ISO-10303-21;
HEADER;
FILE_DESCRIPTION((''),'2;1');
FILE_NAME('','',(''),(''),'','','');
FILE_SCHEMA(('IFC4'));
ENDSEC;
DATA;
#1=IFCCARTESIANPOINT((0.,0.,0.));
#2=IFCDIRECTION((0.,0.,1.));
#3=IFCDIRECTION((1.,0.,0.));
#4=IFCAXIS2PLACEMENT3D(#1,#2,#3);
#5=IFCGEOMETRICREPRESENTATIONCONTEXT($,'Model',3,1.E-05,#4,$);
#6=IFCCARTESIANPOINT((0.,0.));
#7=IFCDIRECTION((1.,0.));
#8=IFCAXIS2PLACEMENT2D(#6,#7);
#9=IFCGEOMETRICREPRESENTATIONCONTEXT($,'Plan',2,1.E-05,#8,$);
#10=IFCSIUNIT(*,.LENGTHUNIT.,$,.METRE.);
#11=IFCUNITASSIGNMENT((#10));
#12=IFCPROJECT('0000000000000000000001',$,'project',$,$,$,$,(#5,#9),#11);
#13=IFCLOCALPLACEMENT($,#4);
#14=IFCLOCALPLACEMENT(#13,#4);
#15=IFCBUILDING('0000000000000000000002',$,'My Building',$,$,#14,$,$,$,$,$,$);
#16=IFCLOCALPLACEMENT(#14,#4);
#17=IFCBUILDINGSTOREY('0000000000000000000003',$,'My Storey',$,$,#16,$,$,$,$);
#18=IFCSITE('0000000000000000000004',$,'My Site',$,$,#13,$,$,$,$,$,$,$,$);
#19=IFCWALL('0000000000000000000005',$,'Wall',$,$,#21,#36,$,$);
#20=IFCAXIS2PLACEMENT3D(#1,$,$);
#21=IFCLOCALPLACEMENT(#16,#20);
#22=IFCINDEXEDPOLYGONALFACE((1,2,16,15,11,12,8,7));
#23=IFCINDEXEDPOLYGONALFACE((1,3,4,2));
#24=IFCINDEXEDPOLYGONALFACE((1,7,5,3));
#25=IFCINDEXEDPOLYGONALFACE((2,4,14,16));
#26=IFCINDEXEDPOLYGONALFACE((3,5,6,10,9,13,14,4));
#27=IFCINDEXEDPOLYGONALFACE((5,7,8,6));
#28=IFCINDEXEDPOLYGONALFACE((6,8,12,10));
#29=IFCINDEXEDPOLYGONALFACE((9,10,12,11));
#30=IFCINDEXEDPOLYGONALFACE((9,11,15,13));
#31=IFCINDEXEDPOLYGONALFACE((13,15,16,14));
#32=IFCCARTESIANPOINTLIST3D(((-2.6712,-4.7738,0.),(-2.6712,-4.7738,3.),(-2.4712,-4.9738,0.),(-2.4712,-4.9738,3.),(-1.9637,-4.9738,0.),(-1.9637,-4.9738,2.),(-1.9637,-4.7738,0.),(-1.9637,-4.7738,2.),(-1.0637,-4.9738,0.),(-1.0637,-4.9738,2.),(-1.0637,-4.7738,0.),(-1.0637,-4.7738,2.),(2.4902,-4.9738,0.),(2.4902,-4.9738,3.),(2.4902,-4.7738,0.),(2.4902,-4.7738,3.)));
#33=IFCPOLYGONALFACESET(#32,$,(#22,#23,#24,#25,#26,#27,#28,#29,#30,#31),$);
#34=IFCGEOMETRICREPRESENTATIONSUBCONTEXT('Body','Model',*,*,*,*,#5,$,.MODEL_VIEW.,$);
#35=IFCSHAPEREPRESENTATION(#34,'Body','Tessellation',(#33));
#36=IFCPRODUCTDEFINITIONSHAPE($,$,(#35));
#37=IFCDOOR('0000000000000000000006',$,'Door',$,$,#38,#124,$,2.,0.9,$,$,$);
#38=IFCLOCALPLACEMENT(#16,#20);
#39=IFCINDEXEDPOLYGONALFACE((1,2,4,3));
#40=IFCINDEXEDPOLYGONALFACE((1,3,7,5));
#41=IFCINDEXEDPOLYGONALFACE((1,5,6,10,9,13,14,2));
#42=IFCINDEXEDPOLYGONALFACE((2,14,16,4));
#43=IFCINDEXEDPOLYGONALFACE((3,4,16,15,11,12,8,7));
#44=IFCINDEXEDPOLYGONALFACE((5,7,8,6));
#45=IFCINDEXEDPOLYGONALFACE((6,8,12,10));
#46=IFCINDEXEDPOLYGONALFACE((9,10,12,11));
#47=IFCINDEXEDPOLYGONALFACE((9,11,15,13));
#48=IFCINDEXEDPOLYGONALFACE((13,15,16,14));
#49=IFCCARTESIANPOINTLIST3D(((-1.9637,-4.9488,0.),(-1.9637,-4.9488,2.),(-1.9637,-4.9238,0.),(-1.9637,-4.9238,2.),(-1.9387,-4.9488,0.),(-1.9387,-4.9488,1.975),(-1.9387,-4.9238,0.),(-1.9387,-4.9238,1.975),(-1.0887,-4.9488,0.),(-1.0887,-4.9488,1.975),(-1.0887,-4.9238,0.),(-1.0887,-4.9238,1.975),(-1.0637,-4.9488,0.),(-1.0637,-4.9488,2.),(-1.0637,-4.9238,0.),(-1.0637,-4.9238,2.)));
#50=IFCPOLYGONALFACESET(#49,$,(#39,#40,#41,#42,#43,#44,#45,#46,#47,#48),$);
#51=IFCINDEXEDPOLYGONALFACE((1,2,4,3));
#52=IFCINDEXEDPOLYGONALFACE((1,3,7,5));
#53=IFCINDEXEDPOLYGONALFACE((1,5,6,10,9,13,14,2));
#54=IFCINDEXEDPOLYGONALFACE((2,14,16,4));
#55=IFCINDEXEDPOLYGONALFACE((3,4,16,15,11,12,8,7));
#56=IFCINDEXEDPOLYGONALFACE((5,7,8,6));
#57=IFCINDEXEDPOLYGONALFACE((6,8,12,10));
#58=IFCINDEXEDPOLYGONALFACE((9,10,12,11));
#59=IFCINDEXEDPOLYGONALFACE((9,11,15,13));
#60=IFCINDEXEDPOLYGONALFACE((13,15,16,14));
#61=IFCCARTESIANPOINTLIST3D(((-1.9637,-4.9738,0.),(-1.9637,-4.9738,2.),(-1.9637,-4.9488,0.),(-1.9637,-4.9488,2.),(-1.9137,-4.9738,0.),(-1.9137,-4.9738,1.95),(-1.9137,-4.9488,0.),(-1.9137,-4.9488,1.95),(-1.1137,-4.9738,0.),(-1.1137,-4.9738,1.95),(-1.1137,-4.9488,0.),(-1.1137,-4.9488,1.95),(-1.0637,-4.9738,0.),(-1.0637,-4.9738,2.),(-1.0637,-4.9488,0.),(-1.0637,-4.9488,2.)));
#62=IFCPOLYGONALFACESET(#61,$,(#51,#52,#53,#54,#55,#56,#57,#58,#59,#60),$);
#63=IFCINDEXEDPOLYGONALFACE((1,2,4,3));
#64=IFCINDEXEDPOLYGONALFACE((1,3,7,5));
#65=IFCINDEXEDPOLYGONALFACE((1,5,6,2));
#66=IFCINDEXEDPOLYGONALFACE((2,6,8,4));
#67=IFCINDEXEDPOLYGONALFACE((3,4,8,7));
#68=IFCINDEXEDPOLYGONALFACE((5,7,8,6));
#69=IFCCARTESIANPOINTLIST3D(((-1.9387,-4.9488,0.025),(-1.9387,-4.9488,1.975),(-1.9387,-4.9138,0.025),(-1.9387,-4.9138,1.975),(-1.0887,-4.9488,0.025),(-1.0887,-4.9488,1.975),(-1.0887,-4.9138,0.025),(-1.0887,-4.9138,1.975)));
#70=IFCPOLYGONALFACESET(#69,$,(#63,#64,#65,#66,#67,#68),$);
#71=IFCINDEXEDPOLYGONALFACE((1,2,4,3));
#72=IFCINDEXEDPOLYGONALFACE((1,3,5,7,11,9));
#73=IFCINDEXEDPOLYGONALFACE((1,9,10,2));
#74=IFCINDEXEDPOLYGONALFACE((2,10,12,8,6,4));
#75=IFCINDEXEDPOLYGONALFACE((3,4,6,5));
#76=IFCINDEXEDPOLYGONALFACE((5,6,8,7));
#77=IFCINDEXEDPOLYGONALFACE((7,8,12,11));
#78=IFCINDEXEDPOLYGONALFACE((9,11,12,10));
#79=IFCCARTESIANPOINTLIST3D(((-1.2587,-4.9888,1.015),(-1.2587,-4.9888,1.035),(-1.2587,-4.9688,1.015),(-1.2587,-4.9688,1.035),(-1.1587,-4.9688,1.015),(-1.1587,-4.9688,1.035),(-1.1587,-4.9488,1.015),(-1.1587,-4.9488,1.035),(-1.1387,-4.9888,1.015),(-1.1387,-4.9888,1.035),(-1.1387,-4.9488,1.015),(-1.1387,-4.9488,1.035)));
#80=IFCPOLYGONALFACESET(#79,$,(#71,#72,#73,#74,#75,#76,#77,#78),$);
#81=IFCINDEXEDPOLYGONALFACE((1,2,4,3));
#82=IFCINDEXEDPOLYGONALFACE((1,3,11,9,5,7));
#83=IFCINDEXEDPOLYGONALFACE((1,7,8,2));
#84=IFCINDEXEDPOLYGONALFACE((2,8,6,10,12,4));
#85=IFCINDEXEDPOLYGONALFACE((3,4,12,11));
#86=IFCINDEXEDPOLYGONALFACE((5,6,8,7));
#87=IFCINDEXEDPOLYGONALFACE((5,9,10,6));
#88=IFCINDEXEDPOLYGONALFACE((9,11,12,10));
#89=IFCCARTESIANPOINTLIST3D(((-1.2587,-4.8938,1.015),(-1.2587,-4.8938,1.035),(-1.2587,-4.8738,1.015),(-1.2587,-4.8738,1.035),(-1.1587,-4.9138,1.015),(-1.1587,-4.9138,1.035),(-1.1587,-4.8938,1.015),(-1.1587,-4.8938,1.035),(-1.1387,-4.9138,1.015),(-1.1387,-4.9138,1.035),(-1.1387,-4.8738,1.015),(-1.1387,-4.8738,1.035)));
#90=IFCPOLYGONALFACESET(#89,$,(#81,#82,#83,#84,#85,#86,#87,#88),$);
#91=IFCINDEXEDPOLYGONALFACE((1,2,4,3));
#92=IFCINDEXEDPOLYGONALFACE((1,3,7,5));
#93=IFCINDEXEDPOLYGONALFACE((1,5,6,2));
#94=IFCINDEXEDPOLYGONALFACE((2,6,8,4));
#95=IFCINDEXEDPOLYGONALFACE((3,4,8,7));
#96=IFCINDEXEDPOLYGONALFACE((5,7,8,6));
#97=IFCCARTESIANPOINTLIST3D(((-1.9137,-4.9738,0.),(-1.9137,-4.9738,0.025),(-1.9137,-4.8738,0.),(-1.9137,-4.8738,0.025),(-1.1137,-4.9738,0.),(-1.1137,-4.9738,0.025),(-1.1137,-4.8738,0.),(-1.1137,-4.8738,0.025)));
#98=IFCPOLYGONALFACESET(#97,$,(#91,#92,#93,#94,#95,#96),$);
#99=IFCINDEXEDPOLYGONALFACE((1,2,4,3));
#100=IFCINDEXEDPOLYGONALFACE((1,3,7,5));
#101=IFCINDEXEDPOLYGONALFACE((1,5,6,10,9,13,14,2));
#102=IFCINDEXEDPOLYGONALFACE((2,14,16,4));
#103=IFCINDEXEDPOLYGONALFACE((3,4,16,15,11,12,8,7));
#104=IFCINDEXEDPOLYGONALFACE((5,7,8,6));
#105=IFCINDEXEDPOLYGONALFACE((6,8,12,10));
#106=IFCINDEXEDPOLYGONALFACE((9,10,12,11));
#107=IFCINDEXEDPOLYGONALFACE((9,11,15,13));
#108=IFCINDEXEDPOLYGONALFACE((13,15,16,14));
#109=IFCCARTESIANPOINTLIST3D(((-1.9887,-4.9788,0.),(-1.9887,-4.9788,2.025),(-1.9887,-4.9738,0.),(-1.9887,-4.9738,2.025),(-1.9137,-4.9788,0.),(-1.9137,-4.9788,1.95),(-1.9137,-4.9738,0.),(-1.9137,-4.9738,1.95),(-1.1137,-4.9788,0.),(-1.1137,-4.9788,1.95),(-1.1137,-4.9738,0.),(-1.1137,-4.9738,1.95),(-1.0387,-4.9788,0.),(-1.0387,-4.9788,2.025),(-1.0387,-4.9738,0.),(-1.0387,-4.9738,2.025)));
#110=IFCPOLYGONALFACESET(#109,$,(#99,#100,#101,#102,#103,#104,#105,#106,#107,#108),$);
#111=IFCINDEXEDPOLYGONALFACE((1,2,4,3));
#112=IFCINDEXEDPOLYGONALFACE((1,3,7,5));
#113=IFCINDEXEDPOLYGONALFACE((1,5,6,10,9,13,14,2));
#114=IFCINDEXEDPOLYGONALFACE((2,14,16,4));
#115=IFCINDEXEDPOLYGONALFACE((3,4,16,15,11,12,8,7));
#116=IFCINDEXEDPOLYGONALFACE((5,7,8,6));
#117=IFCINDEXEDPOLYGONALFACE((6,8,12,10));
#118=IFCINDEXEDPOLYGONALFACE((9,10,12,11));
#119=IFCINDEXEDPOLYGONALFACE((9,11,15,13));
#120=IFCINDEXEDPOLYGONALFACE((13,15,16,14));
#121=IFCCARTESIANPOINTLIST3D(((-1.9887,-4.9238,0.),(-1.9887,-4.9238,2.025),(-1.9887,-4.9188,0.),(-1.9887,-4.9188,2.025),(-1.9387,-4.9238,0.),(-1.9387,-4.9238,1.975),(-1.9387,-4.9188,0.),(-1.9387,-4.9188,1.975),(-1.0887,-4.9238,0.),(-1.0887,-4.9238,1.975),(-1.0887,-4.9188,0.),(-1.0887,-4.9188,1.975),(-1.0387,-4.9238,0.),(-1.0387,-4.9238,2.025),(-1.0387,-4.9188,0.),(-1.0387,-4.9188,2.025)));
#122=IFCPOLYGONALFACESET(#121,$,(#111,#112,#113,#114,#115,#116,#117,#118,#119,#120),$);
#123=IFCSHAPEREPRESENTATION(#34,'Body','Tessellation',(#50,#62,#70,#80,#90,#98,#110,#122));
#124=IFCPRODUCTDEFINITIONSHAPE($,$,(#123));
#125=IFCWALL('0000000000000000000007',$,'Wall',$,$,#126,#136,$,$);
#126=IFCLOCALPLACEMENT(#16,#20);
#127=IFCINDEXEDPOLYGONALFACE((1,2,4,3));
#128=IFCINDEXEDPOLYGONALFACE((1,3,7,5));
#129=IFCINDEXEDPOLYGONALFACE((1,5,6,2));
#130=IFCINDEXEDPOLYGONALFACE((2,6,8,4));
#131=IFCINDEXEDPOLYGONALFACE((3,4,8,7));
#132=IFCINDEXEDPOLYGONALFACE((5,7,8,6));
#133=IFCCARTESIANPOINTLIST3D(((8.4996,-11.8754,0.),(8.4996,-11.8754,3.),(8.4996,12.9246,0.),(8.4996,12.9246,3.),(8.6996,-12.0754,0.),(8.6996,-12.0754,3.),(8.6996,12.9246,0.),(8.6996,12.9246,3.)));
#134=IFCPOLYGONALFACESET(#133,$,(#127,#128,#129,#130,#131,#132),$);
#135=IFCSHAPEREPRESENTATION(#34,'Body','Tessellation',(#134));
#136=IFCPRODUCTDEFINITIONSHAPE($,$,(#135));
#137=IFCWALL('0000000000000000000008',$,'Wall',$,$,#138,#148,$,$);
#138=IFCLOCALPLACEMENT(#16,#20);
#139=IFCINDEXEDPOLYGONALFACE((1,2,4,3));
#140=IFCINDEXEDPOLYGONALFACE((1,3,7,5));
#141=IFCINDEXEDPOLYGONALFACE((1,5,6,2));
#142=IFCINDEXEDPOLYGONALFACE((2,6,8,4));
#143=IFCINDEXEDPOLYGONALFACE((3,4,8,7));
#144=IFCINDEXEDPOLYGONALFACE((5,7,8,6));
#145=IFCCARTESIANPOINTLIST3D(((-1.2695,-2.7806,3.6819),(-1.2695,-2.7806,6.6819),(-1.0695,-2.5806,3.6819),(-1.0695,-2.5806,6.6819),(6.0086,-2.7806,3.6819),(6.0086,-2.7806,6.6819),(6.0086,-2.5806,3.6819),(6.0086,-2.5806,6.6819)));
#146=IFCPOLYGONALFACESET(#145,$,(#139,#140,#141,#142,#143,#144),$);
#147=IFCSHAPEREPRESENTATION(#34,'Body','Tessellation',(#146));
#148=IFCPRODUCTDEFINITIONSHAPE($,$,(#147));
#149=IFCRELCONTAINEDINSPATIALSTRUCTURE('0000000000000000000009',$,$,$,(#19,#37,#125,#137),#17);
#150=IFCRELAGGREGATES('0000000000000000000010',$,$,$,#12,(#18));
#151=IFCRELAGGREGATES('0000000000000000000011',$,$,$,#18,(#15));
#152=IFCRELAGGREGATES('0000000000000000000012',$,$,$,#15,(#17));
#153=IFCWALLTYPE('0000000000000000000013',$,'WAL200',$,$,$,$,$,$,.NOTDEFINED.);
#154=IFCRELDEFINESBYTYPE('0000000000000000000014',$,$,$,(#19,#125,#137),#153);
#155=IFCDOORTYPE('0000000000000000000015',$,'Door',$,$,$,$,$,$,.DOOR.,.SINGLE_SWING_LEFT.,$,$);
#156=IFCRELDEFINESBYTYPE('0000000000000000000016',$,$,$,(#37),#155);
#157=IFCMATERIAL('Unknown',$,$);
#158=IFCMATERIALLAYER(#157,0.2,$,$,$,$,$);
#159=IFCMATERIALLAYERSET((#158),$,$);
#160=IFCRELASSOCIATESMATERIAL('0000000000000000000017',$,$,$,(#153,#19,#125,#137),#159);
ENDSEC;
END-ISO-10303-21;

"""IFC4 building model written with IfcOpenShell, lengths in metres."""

from ifc_helpers import new_model, entity, si_unit, frame, origin_with_axes, origin_2d_with_axis, place, context, subcontext, project, spatial, line, indexed_curve, outline, extrude, shape, source, transform, mapped, material, layer, layer_set, layer_usage, type_object, type_shapes, element, fill, save


model = new_model("IFC4")

# Units and contexts
model_context = context("Model", 3, precision=1e-05, world=origin_with_axes())
plan_context = context("Plan", 2, precision=1e-05, world=origin_2d_with_axis())
body_context_1 = subcontext(model_context, "Body", "Model", "MODEL_VIEW")
body_context_2 = subcontext(plan_context, "Body", "Plan", "PLAN_VIEW")
ifc_project = project(units=[si_unit("LENGTHUNIT", "METRE")], contexts=[model_context, plan_context])

# Site, building, storey
site_placement = place(None, origin_with_axes())
site = spatial("IfcSite", under=ifc_project, at=site_placement, Name="My Site")
building_placement = place(site_placement, origin_with_axes())
building = spatial("IfcBuilding", under=site, at=building_placement, Name="My Building")
storey_placement = place(building_placement, origin_with_axes())
storey = spatial("IfcBuildingStorey", under=building, at=storey_placement, Name="My Storey")

# Shared definitions
ifc_material = material(Name="Unknown")
ifc_layer = layer(ifc_material, 0.2)
ifc_layer_set = layer_set([ifc_layer])
wall_type = type_object("IfcWallType", Name="WAL200", PredefinedType="NOTDEFINED", material=ifc_layer_set)

# Wall, opening, door
shared_shape_1 = source(origin_with_axes(), body_context_1, "Body", "SweptSolid", [
    extrude(outline(indexed_curve([(0.0, 0.0), (0.9, 0.0), (0.9, 2.0), (0.0, 2.0)], segments=[line(1, 2, 3, 4, 1)])), frame((0.0, -0.6, 0.0), z_axis=(0.0, -1.0, 0.0), x_axis=(1.0, 0.0, 0.0)), (0.0, 0.0, -1.0), 1.2),
])
door_type_1 = type_object("IfcDoorType", Name="Door", OperationType="SINGLE_SWING_LEFT", PredefinedType="DOOR")
shared_shape_2 = source(origin_with_axes(), body_context_1, "Body", "SweptSolid", [
    extrude(outline(indexed_curve([(0.0, 0.0), (0.0, 2.0), (0.9, 2.0), (0.9, 0.0), (0.875, 0.0), (0.875, 1.975), (0.025, 1.975), (0.025, 0.0)], segments=[line(1, 2, 3, 4, 5, 6, 7, 8, 1)])), frame((0.0, 0.025, 0.0), z_axis=(0.0, -1.0, 0.0), x_axis=(1.0, 0.0, 0.0)), (0.0, 0.0, -1.0), 0.025),
    extrude(outline(indexed_curve([(0.0, 0.0), (0.0, 2.0), (0.9, 2.0), (0.9, 0.0), (0.85, 0.0), (0.85, 1.95), (0.05, 1.95), (0.05, 0.0)], segments=[line(1, 2, 3, 4, 5, 6, 7, 8, 1)])), frame((0.0, 0.0, 0.0), z_axis=(0.0, -1.0, 0.0), x_axis=(1.0, 0.0, 0.0)), (0.0, 0.0, -1.0), 0.025),
    extrude(outline(indexed_curve([(0.0, 0.0), (0.85, 0.0), (0.85, 0.035), (0.0, 0.035)], segments=[line(1, 2, 3, 4, 1)])), frame((0.025, 0.025, 0.025), z_axis=(0.0, 0.0, 1.0), x_axis=(1.0, 0.0, 0.0)), (0.0, 0.0, 1.0), 1.95),
    extrude(outline(indexed_curve([(0.0, 0.0), (0.0, -0.04), (-0.12, -0.04), (-0.12, -0.02), (-0.02, -0.02), (-0.02, 0.0)], segments=[line(1, 2, 3, 4, 5, 6, 1)])), frame((0.825, 0.025, 1.015), z_axis=(0.0, 0.0, 1.0), x_axis=(1.0, 0.0, 0.0)), (0.0, 0.0, 1.0), 0.02),
    extrude(outline(indexed_curve([(0.0, 0.0), (0.0, 0.04), (-0.12, 0.04), (-0.12, 0.02), (-0.02, 0.02), (-0.02, 0.0)], segments=[line(1, 2, 3, 4, 5, 6, 1)])), frame((0.825, 0.06, 1.015), z_axis=(0.0, 0.0, 1.0), x_axis=(1.0, 0.0, 0.0)), (0.0, 0.0, 1.0), 0.02),
    extrude(outline(indexed_curve([(0.0, 0.0), (0.8, 0.0), (0.8, 0.1), (0.0, 0.1)], segments=[line(1, 2, 3, 4, 1)])), frame((0.05, 0.0, 0.0), z_axis=(0.0, 0.0, 1.0), x_axis=(1.0, 0.0, 0.0)), (0.0, 0.0, 1.0), 0.025),
    extrude(outline(indexed_curve([(0.0, 0.0), (0.0, 2.025), (0.95, 2.025), (0.95, 0.0), (0.875, 0.0), (0.875, 1.95), (0.075, 1.95), (0.075, 0.0)], segments=[line(1, 2, 3, 4, 5, 6, 7, 8, 1)])), frame((-0.025, -0.005, 0.0), z_axis=(0.0, -1.0, 0.0), x_axis=(1.0, 0.0, 0.0)), (0.0, 0.0, -1.0), 0.005),
    extrude(outline(indexed_curve([(0.0, 0.0), (0.0, 2.025), (0.95, 2.025), (0.95, 0.0), (0.9, 0.0), (0.9, 1.975), (0.05, 1.975), (0.05, 0.0)], segments=[line(1, 2, 3, 4, 5, 6, 7, 8, 1)])), frame((-0.025, 0.05, 0.0), z_axis=(0.0, -1.0, 0.0), x_axis=(1.0, 0.0, 0.0)), (0.0, 0.0, -1.0), 0.005),
])
shared_shape_3 = source(origin_with_axes(), body_context_2, "Body", "Curve2D", [
    entity("IfcIndexedPolyCurve", entity("IfcCartesianPointList2D", [[0.0, 0.0], [0.0, 0.05], [0.025, 0.05], [0.025, 0.025], [0.05, 0.025], [0.05, 0.0]]), [entity("IfcLineIndex", [1, 2, 3, 4, 5, 6, 1])]),
    entity("IfcIndexedPolyCurve", entity("IfcCartesianPointList2D", [[0.9, 0.0], [0.9, 0.05], [0.875, 0.05], [0.875, 0.025], [0.85, 0.025], [0.85, 0.0]]), [entity("IfcLineIndex", [1, 2, 3, 4, 5, 6, 1])]),
    entity("IfcTrimmedCurve", entity("IfcEllipse", entity("IfcAxis2Placement2D", entity("IfcCartesianPoint", [0.06, 0.05]), entity("IfcDirection", [1.0, 0.0])), 0.815, 0.85), [entity("IfcCartesianPoint", [0.875, 0.05])], [entity("IfcCartesianPoint", [0.06, 0.9])], True, "CARTESIAN"),
    entity("IfcIndexedPolyCurve", entity("IfcCartesianPointList2D", [[0.025, 0.05], [0.06, 0.05], [0.06, 0.9], [0.025, 0.9]]), [entity("IfcLineIndex", [1, 2, 3, 4, 1])]),
])
type_shapes(door_type_1, [shared_shape_2, shared_shape_3])
ifc_layer_usage_1 = layer_usage(ifc_layer_set, "AXIS2", "POSITIVE", 0.0)
wall_1_placement = place(storey_placement, frame((2.4902, -4.7738, 0.0), z_axis=(0.0, 0.0, 1.0), x_axis=(-1.0, 0.0, 0.0)))
wall_1 = element("IfcWall", 1, at=wall_1_placement, inside=storey, type_object=wall_type, material=ifc_layer_usage_1, Name="Wall", context=body_context_1, shape_type="SweptSolid", body=[
    extrude(outline(indexed_curve([(0.0, 0.0), (0.0, 0.2), (4.9614, 0.2), (5.1614, 0.0)], segments=[line(1, 2, 3, 4, 1)])), origin_with_axes(), (0.0, 0.0, 1.0), 3.0),
])
opening_1_placement = place(wall_1_placement, frame((4.4539, 0.2, 0.0), z_axis=(0.0, 0.0, 1.0), x_axis=(-1.0, 0.0, 0.0)))
opening_1 = element("IfcOpeningElement", 2, at=opening_1_placement, cuts=wall_1, PredefinedType="OPENING", context=body_context_1, shape_type="MappedRepresentation", body=[
    mapped(shared_shape_1, transform((0.0, 0.0, 0.0), x_axis=(1.0, 0.0, 0.0), y_axis=(0.0, 1.0, 0.0), z_axis=(0.0, 0.0, 1.0), scale=1.0)),
])
door_1_placement = place(opening_1_placement, frame((0.0, 0.0, 0.0), z_axis=(0.0, 0.0, 1.0), x_axis=(1.0, 0.0, 0.0)))
door_1 = element("IfcDoor", 3, at=door_1_placement, inside=storey, type_object=door_type_1, Name="Door", OverallHeight=2.0, OverallWidth=0.9, shapes=[
    shape(body_context_1, "Body", "MappedRepresentation", [mapped(shared_shape_2, transform((0.0, 0.0, 0.0), x_axis=(1.0, 0.0, 0.0), y_axis=(0.0, 1.0, 0.0), z_axis=(0.0, 0.0, 1.0), scale=1.0))]),
    shape(body_context_2, "Body", "MappedRepresentation", [mapped(shared_shape_3, transform((0.0, 0.0, 0.0), x_axis=(1.0, 0.0, 0.0), y_axis=(0.0, 1.0, 0.0), z_axis=(0.0, 0.0, 1.0), scale=1.0))]),
])
fill(opening_1, door_1)

# Walls
ifc_layer_usage_2 = layer_usage(ifc_layer_set, "AXIS2", "POSITIVE", 0.0)
wall_2_placement = place(storey_placement, frame((8.6996, -12.0754, 0.0), z_axis=(0.0, 0.0, 1.0), x_axis=(0.0, 1.0, 0.0)))
element("IfcWall", 4, at=wall_2_placement, inside=storey, type_object=wall_type, material=ifc_layer_usage_2, Name="Wall", context=body_context_1, shape_type="SweptSolid", body=[
    extrude(outline(indexed_curve([(0.0, 0.0), (0.2, 0.2), (25.0, 0.2), (25.0, 0.0)], segments=[line(1, 2, 3, 4, 1)])), origin_with_axes(), (0.0, 0.0, 1.0), 3.0),
])
ifc_layer_usage_3 = layer_usage(ifc_layer_set, "AXIS2", "POSITIVE", 0.0)
wall_3_placement = place(storey_placement, frame((-1.2695, -2.7806, 3.6819), z_axis=(0.0, 0.0, 1.0), x_axis=(1.0, 0.0, 0.0)))
element("IfcWall", 5, at=wall_3_placement, inside=storey, type_object=wall_type, material=ifc_layer_usage_3, Name="Wall", context=body_context_1, shape_type="SweptSolid", body=[
    extrude(outline(indexed_curve([(0.0, 0.0), (0.2, 0.2), (7.2781, 0.2), (7.2781, 0.0)], segments=[line(1, 2, 3, 4, 1)])), origin_with_axes(), (0.0, 0.0, 1.0), 3.0),
])

save(model, "model.ifc")
